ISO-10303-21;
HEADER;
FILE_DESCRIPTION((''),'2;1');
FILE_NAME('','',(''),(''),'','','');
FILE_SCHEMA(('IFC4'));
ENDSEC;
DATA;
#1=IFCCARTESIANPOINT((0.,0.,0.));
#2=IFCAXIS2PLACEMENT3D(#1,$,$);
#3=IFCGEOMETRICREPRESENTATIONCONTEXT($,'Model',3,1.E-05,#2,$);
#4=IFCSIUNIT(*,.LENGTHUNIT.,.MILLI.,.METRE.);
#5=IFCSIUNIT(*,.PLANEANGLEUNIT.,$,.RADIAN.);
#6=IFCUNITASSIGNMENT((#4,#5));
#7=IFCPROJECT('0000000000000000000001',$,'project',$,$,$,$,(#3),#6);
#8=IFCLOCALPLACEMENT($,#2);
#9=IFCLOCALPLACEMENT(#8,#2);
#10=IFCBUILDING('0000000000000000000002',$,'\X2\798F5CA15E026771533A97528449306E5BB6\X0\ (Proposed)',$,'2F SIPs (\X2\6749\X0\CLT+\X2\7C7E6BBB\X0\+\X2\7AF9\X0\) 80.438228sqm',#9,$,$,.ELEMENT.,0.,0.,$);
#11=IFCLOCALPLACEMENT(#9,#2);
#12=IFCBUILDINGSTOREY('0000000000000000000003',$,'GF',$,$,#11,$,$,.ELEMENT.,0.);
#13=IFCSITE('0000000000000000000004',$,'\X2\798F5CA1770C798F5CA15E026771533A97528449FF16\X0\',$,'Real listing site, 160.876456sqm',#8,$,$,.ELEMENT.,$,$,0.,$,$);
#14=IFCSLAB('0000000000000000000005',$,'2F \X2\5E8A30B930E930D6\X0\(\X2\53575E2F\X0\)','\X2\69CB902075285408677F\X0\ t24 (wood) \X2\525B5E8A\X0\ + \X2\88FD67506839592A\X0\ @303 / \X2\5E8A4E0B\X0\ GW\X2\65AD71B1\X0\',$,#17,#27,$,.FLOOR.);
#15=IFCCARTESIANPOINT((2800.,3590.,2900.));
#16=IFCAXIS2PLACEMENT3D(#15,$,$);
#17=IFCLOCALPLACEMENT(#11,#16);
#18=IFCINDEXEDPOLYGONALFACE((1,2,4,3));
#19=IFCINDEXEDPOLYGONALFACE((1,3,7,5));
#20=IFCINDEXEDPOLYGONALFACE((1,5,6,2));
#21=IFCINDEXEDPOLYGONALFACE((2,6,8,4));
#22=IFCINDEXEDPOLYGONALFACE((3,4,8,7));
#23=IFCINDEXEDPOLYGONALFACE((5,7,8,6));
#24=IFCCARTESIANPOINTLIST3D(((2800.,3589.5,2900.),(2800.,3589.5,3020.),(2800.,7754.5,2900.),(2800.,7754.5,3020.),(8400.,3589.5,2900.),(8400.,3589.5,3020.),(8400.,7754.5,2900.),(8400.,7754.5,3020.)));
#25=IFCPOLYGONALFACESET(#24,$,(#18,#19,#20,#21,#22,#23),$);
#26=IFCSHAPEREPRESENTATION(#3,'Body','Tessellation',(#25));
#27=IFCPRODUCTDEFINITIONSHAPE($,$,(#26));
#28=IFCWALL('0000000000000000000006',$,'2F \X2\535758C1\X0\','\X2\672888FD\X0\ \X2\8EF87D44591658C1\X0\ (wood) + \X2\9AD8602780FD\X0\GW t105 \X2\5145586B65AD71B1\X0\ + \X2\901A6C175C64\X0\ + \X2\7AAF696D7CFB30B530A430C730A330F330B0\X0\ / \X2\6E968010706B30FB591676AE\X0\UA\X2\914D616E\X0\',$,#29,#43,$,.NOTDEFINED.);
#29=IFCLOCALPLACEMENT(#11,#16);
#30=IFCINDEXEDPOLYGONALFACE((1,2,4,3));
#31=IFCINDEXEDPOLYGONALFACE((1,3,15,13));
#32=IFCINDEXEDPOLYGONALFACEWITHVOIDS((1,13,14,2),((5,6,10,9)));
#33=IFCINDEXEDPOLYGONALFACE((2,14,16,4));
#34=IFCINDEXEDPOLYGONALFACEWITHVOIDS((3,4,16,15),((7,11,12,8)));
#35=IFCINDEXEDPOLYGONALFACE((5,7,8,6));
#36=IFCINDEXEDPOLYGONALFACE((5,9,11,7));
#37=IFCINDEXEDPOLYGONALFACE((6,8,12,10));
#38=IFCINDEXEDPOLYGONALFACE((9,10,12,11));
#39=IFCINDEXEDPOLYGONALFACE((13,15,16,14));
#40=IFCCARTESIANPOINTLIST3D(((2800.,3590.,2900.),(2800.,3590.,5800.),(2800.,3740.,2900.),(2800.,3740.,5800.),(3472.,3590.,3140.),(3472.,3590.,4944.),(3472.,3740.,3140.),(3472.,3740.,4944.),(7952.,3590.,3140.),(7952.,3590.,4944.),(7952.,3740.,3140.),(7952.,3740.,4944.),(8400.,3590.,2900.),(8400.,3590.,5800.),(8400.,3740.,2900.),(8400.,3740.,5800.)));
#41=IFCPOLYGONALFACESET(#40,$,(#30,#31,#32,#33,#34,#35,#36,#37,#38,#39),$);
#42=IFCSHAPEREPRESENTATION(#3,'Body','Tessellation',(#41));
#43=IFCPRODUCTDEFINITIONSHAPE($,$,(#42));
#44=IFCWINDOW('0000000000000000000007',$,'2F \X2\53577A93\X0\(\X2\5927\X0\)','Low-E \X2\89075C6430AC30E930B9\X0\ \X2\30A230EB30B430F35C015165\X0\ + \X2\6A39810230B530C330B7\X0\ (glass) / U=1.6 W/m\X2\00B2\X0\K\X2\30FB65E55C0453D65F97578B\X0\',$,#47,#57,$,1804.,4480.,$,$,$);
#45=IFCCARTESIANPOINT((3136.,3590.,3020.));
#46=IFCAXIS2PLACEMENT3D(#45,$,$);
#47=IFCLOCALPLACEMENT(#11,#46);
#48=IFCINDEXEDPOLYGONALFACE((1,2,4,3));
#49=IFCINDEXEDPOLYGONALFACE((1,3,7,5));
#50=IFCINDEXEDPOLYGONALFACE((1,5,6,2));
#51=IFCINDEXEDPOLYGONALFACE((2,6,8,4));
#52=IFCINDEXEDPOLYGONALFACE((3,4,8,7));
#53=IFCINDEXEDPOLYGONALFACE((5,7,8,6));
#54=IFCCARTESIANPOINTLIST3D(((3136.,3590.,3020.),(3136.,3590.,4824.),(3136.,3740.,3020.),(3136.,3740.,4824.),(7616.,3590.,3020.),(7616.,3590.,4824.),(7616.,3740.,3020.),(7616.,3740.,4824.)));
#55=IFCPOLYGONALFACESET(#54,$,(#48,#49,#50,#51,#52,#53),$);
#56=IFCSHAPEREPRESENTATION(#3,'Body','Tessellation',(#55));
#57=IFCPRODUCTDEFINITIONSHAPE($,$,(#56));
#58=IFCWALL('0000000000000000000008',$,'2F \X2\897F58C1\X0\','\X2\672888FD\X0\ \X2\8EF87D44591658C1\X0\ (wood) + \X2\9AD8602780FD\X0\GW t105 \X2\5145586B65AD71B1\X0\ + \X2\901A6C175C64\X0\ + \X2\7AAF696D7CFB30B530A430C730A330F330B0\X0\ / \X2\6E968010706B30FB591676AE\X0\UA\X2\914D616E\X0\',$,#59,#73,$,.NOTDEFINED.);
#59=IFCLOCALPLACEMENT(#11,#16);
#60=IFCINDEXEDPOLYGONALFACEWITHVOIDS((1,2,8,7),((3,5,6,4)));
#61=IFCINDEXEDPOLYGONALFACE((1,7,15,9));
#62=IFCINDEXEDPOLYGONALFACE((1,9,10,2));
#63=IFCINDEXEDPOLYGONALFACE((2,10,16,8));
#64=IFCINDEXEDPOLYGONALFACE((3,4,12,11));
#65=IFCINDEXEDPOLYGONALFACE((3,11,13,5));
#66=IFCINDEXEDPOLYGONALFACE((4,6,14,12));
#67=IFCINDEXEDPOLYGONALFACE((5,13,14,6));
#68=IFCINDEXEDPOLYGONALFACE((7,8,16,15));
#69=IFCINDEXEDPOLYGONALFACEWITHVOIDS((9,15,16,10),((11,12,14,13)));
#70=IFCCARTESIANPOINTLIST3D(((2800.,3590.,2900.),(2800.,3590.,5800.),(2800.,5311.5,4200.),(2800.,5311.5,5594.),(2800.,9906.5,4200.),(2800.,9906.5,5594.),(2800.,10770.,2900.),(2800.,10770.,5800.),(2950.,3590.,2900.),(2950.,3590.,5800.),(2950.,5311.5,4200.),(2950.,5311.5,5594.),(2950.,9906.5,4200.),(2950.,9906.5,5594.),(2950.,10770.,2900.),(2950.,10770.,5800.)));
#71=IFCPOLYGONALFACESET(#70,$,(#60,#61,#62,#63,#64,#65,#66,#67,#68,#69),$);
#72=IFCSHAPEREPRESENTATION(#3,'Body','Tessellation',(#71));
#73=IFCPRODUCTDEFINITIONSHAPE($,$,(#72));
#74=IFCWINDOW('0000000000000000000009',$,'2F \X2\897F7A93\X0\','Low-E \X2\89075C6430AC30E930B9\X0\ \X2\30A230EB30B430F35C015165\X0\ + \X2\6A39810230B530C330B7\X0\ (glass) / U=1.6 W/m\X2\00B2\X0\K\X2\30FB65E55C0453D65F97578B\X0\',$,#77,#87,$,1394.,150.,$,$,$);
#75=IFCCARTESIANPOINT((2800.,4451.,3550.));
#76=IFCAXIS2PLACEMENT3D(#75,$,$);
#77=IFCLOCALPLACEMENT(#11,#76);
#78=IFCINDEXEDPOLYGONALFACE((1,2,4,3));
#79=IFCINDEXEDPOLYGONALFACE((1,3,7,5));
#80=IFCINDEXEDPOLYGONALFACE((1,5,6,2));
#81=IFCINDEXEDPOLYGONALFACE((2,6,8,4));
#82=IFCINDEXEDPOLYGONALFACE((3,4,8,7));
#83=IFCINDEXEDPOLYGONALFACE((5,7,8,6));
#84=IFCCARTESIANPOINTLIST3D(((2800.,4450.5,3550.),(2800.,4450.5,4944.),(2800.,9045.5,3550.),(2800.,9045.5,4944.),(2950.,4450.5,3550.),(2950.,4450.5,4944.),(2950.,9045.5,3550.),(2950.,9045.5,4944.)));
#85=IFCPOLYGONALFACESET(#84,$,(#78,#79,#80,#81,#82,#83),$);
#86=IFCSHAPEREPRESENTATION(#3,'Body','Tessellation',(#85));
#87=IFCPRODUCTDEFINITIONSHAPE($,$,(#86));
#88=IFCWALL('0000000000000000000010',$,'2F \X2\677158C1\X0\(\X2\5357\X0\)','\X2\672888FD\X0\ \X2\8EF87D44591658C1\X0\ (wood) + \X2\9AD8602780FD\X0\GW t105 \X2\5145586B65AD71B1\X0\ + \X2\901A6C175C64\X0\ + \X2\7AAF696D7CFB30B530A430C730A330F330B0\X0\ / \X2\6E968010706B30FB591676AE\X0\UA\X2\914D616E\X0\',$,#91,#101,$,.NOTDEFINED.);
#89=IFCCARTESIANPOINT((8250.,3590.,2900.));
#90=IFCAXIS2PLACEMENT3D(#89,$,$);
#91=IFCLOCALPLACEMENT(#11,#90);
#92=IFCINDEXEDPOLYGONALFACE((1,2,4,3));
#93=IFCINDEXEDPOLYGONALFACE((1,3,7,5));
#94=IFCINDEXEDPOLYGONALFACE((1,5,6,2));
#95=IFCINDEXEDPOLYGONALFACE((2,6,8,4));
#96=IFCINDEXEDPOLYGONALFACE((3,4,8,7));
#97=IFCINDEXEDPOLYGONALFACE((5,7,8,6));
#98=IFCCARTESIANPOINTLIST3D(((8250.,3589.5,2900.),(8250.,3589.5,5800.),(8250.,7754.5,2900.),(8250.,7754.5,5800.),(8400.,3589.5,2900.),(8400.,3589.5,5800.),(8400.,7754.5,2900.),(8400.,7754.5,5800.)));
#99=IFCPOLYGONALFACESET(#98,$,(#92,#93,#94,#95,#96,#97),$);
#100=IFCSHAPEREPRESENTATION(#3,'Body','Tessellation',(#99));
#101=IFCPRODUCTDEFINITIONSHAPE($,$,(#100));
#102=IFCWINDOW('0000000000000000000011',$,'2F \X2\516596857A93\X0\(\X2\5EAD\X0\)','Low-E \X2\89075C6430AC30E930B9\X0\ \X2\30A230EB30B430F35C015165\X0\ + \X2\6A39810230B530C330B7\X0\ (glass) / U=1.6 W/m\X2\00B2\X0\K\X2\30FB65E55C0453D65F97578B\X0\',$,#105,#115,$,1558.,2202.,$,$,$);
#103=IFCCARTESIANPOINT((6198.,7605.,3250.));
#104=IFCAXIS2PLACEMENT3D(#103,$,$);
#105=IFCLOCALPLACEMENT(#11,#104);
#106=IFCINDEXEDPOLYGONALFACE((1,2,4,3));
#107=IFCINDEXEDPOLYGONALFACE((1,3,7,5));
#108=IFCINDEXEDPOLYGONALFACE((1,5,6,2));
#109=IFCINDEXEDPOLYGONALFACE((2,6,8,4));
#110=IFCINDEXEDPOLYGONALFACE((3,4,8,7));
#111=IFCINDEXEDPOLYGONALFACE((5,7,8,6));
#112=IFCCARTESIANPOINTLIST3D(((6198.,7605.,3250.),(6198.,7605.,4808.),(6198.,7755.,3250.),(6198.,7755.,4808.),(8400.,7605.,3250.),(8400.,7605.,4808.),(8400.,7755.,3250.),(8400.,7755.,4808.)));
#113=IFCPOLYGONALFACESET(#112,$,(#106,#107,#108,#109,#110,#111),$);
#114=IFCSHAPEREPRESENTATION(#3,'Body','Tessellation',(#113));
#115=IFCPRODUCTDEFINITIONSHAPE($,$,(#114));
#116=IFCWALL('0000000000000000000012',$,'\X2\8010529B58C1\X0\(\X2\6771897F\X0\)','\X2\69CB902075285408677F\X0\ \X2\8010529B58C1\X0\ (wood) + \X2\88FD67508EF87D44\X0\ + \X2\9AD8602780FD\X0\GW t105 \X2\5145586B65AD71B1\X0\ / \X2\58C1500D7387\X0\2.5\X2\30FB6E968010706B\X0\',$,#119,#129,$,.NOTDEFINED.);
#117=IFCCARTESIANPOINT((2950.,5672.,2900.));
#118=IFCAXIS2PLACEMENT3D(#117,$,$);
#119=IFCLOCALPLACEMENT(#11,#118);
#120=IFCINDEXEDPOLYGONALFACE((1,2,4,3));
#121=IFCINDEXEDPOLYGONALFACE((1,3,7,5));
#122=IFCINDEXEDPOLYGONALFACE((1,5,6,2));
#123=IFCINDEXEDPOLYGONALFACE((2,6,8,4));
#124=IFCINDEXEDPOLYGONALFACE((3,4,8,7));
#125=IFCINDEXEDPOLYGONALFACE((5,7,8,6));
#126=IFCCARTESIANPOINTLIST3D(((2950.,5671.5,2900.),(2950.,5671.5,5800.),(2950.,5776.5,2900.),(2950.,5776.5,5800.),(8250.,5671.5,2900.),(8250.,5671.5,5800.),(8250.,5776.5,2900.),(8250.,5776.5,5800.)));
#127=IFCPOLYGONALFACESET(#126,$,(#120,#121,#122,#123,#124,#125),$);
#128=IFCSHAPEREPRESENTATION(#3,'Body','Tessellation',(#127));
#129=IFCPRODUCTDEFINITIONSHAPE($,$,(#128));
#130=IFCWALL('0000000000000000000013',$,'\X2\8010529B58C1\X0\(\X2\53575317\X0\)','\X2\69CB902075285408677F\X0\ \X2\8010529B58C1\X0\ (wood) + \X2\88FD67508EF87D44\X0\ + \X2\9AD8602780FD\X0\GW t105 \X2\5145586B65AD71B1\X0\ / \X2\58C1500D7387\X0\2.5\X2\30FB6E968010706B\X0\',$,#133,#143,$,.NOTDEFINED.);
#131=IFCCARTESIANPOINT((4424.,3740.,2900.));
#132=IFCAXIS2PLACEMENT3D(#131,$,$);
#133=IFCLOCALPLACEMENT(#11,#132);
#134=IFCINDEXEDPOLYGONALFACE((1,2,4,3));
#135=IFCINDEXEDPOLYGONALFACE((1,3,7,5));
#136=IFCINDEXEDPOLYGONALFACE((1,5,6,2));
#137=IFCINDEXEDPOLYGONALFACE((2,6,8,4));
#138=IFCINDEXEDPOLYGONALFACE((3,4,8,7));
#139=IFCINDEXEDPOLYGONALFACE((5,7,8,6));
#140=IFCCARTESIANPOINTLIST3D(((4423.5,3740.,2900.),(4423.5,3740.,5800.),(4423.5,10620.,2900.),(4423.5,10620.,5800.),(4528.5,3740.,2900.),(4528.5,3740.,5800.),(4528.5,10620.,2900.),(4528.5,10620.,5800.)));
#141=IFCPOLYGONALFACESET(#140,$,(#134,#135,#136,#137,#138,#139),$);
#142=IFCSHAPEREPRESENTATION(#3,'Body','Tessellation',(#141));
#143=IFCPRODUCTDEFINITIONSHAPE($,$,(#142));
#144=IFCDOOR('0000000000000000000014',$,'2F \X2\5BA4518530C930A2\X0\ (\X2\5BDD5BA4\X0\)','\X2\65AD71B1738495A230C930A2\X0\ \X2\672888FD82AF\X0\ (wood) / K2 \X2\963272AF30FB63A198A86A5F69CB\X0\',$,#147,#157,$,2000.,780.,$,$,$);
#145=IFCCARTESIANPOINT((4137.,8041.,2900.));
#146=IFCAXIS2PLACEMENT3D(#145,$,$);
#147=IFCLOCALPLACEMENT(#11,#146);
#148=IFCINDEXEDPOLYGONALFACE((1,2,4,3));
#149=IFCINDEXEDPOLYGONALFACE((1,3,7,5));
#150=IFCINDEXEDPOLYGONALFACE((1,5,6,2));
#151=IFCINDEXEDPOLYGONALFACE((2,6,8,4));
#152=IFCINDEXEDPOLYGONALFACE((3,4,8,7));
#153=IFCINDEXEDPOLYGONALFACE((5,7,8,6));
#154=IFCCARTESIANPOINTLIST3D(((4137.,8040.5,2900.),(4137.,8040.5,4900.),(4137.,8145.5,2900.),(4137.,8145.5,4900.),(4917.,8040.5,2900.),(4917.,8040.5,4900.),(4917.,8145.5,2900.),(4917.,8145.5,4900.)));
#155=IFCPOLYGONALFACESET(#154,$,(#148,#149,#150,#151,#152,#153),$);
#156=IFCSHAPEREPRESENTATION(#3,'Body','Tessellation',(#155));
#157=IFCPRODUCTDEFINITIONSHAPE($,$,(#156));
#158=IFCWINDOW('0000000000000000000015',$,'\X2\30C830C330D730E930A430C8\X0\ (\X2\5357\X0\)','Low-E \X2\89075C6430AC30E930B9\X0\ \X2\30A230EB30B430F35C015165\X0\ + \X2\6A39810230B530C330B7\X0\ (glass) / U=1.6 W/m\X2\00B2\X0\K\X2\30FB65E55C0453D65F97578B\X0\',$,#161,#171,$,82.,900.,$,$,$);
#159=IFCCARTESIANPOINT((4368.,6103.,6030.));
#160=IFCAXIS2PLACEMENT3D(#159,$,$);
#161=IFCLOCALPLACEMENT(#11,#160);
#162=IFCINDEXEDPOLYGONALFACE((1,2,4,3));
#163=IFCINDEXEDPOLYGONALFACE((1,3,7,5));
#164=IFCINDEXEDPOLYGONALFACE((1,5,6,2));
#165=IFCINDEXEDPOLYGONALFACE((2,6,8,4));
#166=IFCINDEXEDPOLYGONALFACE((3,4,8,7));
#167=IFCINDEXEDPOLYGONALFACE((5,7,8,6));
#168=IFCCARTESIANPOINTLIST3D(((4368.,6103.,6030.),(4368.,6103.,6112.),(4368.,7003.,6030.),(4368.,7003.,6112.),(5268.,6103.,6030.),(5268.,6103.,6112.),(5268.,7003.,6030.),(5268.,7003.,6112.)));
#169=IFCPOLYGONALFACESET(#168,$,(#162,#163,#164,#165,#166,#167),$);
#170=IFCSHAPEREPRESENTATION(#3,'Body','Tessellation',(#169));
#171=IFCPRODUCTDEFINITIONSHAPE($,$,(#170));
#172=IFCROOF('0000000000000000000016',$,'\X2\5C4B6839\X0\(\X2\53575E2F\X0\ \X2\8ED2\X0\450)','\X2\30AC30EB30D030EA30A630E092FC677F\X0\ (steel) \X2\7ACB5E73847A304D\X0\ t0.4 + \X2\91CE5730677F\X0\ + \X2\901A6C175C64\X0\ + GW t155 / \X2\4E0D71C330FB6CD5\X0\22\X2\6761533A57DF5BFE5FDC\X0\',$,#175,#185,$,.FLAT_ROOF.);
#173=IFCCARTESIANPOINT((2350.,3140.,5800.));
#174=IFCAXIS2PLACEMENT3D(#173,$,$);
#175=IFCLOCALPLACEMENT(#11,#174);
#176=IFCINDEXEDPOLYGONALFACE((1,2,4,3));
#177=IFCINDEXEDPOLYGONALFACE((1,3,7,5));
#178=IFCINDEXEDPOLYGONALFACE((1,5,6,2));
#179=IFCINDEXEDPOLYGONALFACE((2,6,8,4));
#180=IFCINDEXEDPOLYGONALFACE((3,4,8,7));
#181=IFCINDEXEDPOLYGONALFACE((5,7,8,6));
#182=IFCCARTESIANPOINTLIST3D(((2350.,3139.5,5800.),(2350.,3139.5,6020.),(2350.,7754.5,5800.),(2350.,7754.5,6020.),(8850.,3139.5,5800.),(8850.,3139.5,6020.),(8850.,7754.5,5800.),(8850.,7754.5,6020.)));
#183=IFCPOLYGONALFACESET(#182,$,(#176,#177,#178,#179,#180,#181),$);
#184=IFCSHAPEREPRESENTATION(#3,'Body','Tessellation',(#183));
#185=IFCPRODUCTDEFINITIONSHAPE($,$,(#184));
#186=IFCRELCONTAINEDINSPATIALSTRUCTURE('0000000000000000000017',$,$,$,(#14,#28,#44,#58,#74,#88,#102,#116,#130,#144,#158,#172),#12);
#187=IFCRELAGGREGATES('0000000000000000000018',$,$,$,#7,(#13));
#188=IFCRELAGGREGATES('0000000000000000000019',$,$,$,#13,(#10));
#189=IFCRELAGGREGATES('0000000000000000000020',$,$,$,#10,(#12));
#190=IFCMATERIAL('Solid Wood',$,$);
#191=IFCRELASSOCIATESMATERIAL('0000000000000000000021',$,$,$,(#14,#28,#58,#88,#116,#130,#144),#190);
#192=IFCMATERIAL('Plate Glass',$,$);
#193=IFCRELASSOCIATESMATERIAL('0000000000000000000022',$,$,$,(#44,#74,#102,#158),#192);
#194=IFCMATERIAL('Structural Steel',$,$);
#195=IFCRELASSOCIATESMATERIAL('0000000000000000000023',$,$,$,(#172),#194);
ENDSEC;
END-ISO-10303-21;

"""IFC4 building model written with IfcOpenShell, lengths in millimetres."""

from ifc_helpers import new_model, si_unit, frame, frame_2d, origin, place, context, project, spatial, rectangle, extrude, material, element, fill, save


model = new_model("IFC4")

# Units and contexts
model_context = context("Model", 3, precision=1e-05, world=origin())
ifc_project = project(units=[si_unit("LENGTHUNIT", "METRE", prefix="MILLI"), si_unit("PLANEANGLEUNIT", "RADIAN")], contexts=[model_context])

# Site, building, storey
site_placement = place(None, origin())
site = spatial("IfcSite", under=ifc_project, at=site_placement, Name="福岡県福岡市東区青葉６", ObjectType="Real listing site, 160.876456sqm", CompositionType="ELEMENT", RefElevation=0.0)
building_placement = place(site_placement, origin())
building = spatial("IfcBuilding", under=site, at=building_placement, Name="福岡市東区青葉の家 (Proposed)", ObjectType="2F SIPs (杉CLT+籾殻+竹) 80.438228sqm", CompositionType="ELEMENT", ElevationOfRefHeight=0.0, ElevationOfTerrain=0.0)
storey_placement = place(building_placement, origin())
storey = spatial("IfcBuildingStorey", under=building, at=storey_placement, Name="GF", CompositionType="ELEMENT", Elevation=0.0)

# Slab
ifc_material_1 = material(Name="Solid Wood")
slab_placement = place(storey_placement, frame((2800.0, 3590.0, 2900.0)))
element("IfcSlab", 1, at=slab_placement, inside=storey, material=ifc_material_1, Name="2F 床スラブ(南帯)", Description="構造用合板 t24 (wood) 剛床 + 製材根太 @303 / 床下 GW断熱", PredefinedType="FLOOR", context=model_context, shape_type="SweptSolid", body=[
    extrude(rectangle(XDim=5600.0, YDim=4165.0, at=frame_2d((2800.0, 2082.0))), frame((2800.0, 3590.0, 2900.0)), (0.0, 0.0, 1.0), 120.0),
])

# Walls, openings, windows
wall_1_placement = place(storey_placement, frame((2800.0, 3590.0, 2900.0)))
wall_1 = element("IfcWall", 2, at=wall_1_placement, inside=storey, material=ifc_material_1, Name="2F 南壁", Description="木製 軸組外壁 (wood) + 高性能GW t105 充填断熱 + 通気層 + 窯業系サイディング / 準耐火・外皮UA配慮", PredefinedType="NOTDEFINED", context=model_context, shape_type="SweptSolid", body=[
    extrude(rectangle(XDim=5600.0, YDim=150.0, at=frame_2d((2800.0, 75.0))), frame((2800.0, 3590.0, 2900.0)), (0.0, 0.0, 1.0), 2900.0),
])
opening_1_placement = place(storey_placement, frame((3136.0, 3590.0, 3020.0)))
opening_1 = element("IfcOpeningElement", 3, at=opening_1_placement, cuts=wall_1, PredefinedType="NOTDEFINED", context=model_context, shape_type="SweptSolid", body=[
    extrude(rectangle(XDim=4480.0, YDim=150.0, at=frame_2d((2240.0, 75.0))), frame((3136.0, 3590.0, 3020.0)), (0.0, 0.0, 1.0), 1804.0),
])
ifc_material_2 = material(Name="Plate Glass")
window_1_placement = place(storey_placement, frame((3136.0, 3590.0, 3020.0)))
window_1 = element("IfcWindow", 4, at=window_1_placement, inside=storey, material=ifc_material_2, Name="2F 南窓(大)", Description="Low-E 複層ガラス アルゴン封入 + 樹脂サッシ (glass) / U=1.6 W/m²K・日射取得型", OverallHeight=1804.0, OverallWidth=4480.0, context=model_context, shape_type="SweptSolid", body=[
    extrude(rectangle(XDim=4480.0, YDim=150.0, at=frame_2d((2240.0, 75.0))), frame((3136.0, 3590.0, 3020.0)), (0.0, 0.0, 1.0), 1804.0),
])
fill(opening_1, window_1)
wall_2_placement = place(storey_placement, frame((2800.0, 3590.0, 2900.0)))
wall_2 = element("IfcWall", 5, at=wall_2_placement, inside=storey, material=ifc_material_1, Name="2F 西壁", Description="木製 軸組外壁 (wood) + 高性能GW t105 充填断熱 + 通気層 + 窯業系サイディング / 準耐火・外皮UA配慮", PredefinedType="NOTDEFINED", context=model_context, shape_type="SweptSolid", body=[
    extrude(rectangle(XDim=150.0, YDim=7180.0, at=frame_2d((75.0, 3590.0))), frame((2800.0, 3590.0, 2900.0)), (0.0, 0.0, 1.0), 2900.0),
])
opening_2_placement = place(storey_placement, frame((2800.0, 4451.0, 3550.0)))
opening_2 = element("IfcOpeningElement", 6, at=opening_2_placement, cuts=wall_2, PredefinedType="NOTDEFINED", context=model_context, shape_type="SweptSolid", body=[
    extrude(rectangle(XDim=150.0, YDim=4595.0, at=frame_2d((75.0, 2297.0))), frame((2800.0, 4451.0, 3550.0)), (0.0, 0.0, 1.0), 1394.0),
])
window_2_placement = place(storey_placement, frame((2800.0, 4451.0, 3550.0)))
window_2 = element("IfcWindow", 7, at=window_2_placement, inside=storey, material=ifc_material_2, Name="2F 西窓", Description="Low-E 複層ガラス アルゴン封入 + 樹脂サッシ (glass) / U=1.6 W/m²K・日射取得型", OverallHeight=1394.0, OverallWidth=150.0, context=model_context, shape_type="SweptSolid", body=[
    extrude(rectangle(XDim=150.0, YDim=4595.0, at=frame_2d((75.0, 2297.0))), frame((2800.0, 4451.0, 3550.0)), (0.0, 0.0, 1.0), 1394.0),
])
fill(opening_2, window_2)
wall_3_placement = place(storey_placement, frame((8250.0, 3590.0, 2900.0)))
wall_3 = element("IfcWall", 8, at=wall_3_placement, inside=storey, material=ifc_material_1, Name="2F 東壁(南)", Description="木製 軸組外壁 (wood) + 高性能GW t105 充填断熱 + 通気層 + 窯業系サイディング / 準耐火・外皮UA配慮", PredefinedType="NOTDEFINED", context=model_context, shape_type="SweptSolid", body=[
    extrude(rectangle(XDim=150.0, YDim=4165.0, at=frame_2d((75.0, 2082.0))), frame((8250.0, 3590.0, 2900.0)), (0.0, 0.0, 1.0), 2900.0),
])
opening_3_placement = place(storey_placement, frame((6198.0, 7605.0, 3250.0)))
opening_3 = element("IfcOpeningElement", 9, at=opening_3_placement, cuts=wall_3, PredefinedType="NOTDEFINED", context=model_context, shape_type="SweptSolid", body=[
    extrude(rectangle(XDim=2202.0, YDim=150.0, at=frame_2d((1101.0, 75.0))), frame((6198.0, 7605.0, 3250.0)), (0.0, 0.0, 1.0), 1558.0),
])
window_3_placement = place(storey_placement, frame((6198.0, 7605.0, 3250.0)))
window_3 = element("IfcWindow", 10, at=window_3_placement, inside=storey, material=ifc_material_2, Name="2F 入隅窓(庭)", Description="Low-E 複層ガラス アルゴン封入 + 樹脂サッシ (glass) / U=1.6 W/m²K・日射取得型", OverallHeight=1558.0, OverallWidth=2202.0, context=model_context, shape_type="SweptSolid", body=[
    extrude(rectangle(XDim=2202.0, YDim=150.0, at=frame_2d((1101.0, 75.0))), frame((6198.0, 7605.0, 3250.0)), (0.0, 0.0, 1.0), 1558.0),
])
fill(opening_3, window_3)

# Wall
wall_4_placement = place(storey_placement, frame((2950.0, 5672.0, 2900.0)))
element("IfcWall", 11, at=wall_4_placement, inside=storey, material=ifc_material_1, Name="耐力壁(東西)", Description="構造用合板 耐力壁 (wood) + 製材軸組 + 高性能GW t105 充填断熱 / 壁倍率2.5・準耐火", PredefinedType="NOTDEFINED", context=model_context, shape_type="SweptSolid", body=[
    extrude(rectangle(XDim=5300.0, YDim=105.0, at=frame_2d((2650.0, 52.0))), frame((2950.0, 5672.0, 2900.0)), (0.0, 0.0, 1.0), 2900.0),
])

# Wall, opening, door
wall_5_placement = place(storey_placement, frame((4424.0, 3740.0, 2900.0)))
wall_5 = element("IfcWall", 12, at=wall_5_placement, inside=storey, material=ifc_material_1, Name="耐力壁(南北)", Description="構造用合板 耐力壁 (wood) + 製材軸組 + 高性能GW t105 充填断熱 / 壁倍率2.5・準耐火", PredefinedType="NOTDEFINED", context=model_context, shape_type="SweptSolid", body=[
    extrude(rectangle(XDim=105.0, YDim=6880.0, at=frame_2d((52.0, 3440.0))), frame((4424.0, 3740.0, 2900.0)), (0.0, 0.0, 1.0), 2900.0),
])
opening_4_placement = place(storey_placement, frame((4137.0, 8041.0, 2900.0)))
opening_4 = element("IfcOpeningElement", 13, at=opening_4_placement, cuts=wall_5, PredefinedType="NOTDEFINED", context=model_context, shape_type="SweptSolid", body=[
    extrude(rectangle(XDim=780.0, YDim=105.0, at=frame_2d((390.0, 52.0))), frame((4137.0, 8041.0, 2900.0)), (0.0, 0.0, 1.0), 2000.0),
])
door_placement = place(storey_placement, frame((4137.0, 8041.0, 2900.0)))
door = element("IfcDoor", 14, at=door_placement, inside=storey, material=ifc_material_1, Name="2F 室内ドア (寝室)", Description="断熱玄関ドア 木製芯 (wood) / K2 防犯・採風機構", OverallHeight=2000.0, OverallWidth=780.0, context=model_context, shape_type="SweptSolid", body=[
    extrude(rectangle(XDim=780.0, YDim=105.0, at=frame_2d((390.0, 52.0))), frame((4137.0, 8041.0, 2900.0)), (0.0, 0.0, 1.0), 2000.0),
])
fill(opening_4, door)

# Window
window_4_placement = place(storey_placement, frame((4368.0, 6103.0, 6030.0)))
element("IfcWindow", 15, at=window_4_placement, inside=storey, material=ifc_material_2, Name="トップライト (南)", Description="Low-E 複層ガラス アルゴン封入 + 樹脂サッシ (glass) / U=1.6 W/m²K・日射取得型", OverallHeight=82.0, OverallWidth=900.0, context=model_context, shape_type="SweptSolid", body=[
    extrude(rectangle(XDim=900.0, YDim=900.0, at=frame_2d((450.0, 450.0))), frame((4368.0, 6103.0, 6030.0)), (0.0, 0.0, 1.0), 82.0),
])

# Roof
ifc_material_3 = material(Name="Structural Steel")
for number, where, name in (
    (16, (2350.0, 3140.0, 5800.0), "屋根(南帯 軒450)"),
):
    element("IfcRoof", number, at=place(storey_placement, frame(where)), inside=storey, material=ifc_material_3, Name=name, Description="ガルバリウム鋼板 (steel) 立平葺き t0.4 + 野地板 + 通気層 + GW t155 / 不燃・法22条区域対応", PredefinedType="FLAT_ROOF", context=model_context, shape_type="SweptSolid", body=[
        extrude(rectangle(XDim=6500.0, YDim=4615.0, at=frame_2d((3250.0, 2307.0))), frame((2350.0, 3140.0, 5800.0)), (0.0, 0.0, 1.0), 220.0),
    ])

save(model, "model.ifc")
